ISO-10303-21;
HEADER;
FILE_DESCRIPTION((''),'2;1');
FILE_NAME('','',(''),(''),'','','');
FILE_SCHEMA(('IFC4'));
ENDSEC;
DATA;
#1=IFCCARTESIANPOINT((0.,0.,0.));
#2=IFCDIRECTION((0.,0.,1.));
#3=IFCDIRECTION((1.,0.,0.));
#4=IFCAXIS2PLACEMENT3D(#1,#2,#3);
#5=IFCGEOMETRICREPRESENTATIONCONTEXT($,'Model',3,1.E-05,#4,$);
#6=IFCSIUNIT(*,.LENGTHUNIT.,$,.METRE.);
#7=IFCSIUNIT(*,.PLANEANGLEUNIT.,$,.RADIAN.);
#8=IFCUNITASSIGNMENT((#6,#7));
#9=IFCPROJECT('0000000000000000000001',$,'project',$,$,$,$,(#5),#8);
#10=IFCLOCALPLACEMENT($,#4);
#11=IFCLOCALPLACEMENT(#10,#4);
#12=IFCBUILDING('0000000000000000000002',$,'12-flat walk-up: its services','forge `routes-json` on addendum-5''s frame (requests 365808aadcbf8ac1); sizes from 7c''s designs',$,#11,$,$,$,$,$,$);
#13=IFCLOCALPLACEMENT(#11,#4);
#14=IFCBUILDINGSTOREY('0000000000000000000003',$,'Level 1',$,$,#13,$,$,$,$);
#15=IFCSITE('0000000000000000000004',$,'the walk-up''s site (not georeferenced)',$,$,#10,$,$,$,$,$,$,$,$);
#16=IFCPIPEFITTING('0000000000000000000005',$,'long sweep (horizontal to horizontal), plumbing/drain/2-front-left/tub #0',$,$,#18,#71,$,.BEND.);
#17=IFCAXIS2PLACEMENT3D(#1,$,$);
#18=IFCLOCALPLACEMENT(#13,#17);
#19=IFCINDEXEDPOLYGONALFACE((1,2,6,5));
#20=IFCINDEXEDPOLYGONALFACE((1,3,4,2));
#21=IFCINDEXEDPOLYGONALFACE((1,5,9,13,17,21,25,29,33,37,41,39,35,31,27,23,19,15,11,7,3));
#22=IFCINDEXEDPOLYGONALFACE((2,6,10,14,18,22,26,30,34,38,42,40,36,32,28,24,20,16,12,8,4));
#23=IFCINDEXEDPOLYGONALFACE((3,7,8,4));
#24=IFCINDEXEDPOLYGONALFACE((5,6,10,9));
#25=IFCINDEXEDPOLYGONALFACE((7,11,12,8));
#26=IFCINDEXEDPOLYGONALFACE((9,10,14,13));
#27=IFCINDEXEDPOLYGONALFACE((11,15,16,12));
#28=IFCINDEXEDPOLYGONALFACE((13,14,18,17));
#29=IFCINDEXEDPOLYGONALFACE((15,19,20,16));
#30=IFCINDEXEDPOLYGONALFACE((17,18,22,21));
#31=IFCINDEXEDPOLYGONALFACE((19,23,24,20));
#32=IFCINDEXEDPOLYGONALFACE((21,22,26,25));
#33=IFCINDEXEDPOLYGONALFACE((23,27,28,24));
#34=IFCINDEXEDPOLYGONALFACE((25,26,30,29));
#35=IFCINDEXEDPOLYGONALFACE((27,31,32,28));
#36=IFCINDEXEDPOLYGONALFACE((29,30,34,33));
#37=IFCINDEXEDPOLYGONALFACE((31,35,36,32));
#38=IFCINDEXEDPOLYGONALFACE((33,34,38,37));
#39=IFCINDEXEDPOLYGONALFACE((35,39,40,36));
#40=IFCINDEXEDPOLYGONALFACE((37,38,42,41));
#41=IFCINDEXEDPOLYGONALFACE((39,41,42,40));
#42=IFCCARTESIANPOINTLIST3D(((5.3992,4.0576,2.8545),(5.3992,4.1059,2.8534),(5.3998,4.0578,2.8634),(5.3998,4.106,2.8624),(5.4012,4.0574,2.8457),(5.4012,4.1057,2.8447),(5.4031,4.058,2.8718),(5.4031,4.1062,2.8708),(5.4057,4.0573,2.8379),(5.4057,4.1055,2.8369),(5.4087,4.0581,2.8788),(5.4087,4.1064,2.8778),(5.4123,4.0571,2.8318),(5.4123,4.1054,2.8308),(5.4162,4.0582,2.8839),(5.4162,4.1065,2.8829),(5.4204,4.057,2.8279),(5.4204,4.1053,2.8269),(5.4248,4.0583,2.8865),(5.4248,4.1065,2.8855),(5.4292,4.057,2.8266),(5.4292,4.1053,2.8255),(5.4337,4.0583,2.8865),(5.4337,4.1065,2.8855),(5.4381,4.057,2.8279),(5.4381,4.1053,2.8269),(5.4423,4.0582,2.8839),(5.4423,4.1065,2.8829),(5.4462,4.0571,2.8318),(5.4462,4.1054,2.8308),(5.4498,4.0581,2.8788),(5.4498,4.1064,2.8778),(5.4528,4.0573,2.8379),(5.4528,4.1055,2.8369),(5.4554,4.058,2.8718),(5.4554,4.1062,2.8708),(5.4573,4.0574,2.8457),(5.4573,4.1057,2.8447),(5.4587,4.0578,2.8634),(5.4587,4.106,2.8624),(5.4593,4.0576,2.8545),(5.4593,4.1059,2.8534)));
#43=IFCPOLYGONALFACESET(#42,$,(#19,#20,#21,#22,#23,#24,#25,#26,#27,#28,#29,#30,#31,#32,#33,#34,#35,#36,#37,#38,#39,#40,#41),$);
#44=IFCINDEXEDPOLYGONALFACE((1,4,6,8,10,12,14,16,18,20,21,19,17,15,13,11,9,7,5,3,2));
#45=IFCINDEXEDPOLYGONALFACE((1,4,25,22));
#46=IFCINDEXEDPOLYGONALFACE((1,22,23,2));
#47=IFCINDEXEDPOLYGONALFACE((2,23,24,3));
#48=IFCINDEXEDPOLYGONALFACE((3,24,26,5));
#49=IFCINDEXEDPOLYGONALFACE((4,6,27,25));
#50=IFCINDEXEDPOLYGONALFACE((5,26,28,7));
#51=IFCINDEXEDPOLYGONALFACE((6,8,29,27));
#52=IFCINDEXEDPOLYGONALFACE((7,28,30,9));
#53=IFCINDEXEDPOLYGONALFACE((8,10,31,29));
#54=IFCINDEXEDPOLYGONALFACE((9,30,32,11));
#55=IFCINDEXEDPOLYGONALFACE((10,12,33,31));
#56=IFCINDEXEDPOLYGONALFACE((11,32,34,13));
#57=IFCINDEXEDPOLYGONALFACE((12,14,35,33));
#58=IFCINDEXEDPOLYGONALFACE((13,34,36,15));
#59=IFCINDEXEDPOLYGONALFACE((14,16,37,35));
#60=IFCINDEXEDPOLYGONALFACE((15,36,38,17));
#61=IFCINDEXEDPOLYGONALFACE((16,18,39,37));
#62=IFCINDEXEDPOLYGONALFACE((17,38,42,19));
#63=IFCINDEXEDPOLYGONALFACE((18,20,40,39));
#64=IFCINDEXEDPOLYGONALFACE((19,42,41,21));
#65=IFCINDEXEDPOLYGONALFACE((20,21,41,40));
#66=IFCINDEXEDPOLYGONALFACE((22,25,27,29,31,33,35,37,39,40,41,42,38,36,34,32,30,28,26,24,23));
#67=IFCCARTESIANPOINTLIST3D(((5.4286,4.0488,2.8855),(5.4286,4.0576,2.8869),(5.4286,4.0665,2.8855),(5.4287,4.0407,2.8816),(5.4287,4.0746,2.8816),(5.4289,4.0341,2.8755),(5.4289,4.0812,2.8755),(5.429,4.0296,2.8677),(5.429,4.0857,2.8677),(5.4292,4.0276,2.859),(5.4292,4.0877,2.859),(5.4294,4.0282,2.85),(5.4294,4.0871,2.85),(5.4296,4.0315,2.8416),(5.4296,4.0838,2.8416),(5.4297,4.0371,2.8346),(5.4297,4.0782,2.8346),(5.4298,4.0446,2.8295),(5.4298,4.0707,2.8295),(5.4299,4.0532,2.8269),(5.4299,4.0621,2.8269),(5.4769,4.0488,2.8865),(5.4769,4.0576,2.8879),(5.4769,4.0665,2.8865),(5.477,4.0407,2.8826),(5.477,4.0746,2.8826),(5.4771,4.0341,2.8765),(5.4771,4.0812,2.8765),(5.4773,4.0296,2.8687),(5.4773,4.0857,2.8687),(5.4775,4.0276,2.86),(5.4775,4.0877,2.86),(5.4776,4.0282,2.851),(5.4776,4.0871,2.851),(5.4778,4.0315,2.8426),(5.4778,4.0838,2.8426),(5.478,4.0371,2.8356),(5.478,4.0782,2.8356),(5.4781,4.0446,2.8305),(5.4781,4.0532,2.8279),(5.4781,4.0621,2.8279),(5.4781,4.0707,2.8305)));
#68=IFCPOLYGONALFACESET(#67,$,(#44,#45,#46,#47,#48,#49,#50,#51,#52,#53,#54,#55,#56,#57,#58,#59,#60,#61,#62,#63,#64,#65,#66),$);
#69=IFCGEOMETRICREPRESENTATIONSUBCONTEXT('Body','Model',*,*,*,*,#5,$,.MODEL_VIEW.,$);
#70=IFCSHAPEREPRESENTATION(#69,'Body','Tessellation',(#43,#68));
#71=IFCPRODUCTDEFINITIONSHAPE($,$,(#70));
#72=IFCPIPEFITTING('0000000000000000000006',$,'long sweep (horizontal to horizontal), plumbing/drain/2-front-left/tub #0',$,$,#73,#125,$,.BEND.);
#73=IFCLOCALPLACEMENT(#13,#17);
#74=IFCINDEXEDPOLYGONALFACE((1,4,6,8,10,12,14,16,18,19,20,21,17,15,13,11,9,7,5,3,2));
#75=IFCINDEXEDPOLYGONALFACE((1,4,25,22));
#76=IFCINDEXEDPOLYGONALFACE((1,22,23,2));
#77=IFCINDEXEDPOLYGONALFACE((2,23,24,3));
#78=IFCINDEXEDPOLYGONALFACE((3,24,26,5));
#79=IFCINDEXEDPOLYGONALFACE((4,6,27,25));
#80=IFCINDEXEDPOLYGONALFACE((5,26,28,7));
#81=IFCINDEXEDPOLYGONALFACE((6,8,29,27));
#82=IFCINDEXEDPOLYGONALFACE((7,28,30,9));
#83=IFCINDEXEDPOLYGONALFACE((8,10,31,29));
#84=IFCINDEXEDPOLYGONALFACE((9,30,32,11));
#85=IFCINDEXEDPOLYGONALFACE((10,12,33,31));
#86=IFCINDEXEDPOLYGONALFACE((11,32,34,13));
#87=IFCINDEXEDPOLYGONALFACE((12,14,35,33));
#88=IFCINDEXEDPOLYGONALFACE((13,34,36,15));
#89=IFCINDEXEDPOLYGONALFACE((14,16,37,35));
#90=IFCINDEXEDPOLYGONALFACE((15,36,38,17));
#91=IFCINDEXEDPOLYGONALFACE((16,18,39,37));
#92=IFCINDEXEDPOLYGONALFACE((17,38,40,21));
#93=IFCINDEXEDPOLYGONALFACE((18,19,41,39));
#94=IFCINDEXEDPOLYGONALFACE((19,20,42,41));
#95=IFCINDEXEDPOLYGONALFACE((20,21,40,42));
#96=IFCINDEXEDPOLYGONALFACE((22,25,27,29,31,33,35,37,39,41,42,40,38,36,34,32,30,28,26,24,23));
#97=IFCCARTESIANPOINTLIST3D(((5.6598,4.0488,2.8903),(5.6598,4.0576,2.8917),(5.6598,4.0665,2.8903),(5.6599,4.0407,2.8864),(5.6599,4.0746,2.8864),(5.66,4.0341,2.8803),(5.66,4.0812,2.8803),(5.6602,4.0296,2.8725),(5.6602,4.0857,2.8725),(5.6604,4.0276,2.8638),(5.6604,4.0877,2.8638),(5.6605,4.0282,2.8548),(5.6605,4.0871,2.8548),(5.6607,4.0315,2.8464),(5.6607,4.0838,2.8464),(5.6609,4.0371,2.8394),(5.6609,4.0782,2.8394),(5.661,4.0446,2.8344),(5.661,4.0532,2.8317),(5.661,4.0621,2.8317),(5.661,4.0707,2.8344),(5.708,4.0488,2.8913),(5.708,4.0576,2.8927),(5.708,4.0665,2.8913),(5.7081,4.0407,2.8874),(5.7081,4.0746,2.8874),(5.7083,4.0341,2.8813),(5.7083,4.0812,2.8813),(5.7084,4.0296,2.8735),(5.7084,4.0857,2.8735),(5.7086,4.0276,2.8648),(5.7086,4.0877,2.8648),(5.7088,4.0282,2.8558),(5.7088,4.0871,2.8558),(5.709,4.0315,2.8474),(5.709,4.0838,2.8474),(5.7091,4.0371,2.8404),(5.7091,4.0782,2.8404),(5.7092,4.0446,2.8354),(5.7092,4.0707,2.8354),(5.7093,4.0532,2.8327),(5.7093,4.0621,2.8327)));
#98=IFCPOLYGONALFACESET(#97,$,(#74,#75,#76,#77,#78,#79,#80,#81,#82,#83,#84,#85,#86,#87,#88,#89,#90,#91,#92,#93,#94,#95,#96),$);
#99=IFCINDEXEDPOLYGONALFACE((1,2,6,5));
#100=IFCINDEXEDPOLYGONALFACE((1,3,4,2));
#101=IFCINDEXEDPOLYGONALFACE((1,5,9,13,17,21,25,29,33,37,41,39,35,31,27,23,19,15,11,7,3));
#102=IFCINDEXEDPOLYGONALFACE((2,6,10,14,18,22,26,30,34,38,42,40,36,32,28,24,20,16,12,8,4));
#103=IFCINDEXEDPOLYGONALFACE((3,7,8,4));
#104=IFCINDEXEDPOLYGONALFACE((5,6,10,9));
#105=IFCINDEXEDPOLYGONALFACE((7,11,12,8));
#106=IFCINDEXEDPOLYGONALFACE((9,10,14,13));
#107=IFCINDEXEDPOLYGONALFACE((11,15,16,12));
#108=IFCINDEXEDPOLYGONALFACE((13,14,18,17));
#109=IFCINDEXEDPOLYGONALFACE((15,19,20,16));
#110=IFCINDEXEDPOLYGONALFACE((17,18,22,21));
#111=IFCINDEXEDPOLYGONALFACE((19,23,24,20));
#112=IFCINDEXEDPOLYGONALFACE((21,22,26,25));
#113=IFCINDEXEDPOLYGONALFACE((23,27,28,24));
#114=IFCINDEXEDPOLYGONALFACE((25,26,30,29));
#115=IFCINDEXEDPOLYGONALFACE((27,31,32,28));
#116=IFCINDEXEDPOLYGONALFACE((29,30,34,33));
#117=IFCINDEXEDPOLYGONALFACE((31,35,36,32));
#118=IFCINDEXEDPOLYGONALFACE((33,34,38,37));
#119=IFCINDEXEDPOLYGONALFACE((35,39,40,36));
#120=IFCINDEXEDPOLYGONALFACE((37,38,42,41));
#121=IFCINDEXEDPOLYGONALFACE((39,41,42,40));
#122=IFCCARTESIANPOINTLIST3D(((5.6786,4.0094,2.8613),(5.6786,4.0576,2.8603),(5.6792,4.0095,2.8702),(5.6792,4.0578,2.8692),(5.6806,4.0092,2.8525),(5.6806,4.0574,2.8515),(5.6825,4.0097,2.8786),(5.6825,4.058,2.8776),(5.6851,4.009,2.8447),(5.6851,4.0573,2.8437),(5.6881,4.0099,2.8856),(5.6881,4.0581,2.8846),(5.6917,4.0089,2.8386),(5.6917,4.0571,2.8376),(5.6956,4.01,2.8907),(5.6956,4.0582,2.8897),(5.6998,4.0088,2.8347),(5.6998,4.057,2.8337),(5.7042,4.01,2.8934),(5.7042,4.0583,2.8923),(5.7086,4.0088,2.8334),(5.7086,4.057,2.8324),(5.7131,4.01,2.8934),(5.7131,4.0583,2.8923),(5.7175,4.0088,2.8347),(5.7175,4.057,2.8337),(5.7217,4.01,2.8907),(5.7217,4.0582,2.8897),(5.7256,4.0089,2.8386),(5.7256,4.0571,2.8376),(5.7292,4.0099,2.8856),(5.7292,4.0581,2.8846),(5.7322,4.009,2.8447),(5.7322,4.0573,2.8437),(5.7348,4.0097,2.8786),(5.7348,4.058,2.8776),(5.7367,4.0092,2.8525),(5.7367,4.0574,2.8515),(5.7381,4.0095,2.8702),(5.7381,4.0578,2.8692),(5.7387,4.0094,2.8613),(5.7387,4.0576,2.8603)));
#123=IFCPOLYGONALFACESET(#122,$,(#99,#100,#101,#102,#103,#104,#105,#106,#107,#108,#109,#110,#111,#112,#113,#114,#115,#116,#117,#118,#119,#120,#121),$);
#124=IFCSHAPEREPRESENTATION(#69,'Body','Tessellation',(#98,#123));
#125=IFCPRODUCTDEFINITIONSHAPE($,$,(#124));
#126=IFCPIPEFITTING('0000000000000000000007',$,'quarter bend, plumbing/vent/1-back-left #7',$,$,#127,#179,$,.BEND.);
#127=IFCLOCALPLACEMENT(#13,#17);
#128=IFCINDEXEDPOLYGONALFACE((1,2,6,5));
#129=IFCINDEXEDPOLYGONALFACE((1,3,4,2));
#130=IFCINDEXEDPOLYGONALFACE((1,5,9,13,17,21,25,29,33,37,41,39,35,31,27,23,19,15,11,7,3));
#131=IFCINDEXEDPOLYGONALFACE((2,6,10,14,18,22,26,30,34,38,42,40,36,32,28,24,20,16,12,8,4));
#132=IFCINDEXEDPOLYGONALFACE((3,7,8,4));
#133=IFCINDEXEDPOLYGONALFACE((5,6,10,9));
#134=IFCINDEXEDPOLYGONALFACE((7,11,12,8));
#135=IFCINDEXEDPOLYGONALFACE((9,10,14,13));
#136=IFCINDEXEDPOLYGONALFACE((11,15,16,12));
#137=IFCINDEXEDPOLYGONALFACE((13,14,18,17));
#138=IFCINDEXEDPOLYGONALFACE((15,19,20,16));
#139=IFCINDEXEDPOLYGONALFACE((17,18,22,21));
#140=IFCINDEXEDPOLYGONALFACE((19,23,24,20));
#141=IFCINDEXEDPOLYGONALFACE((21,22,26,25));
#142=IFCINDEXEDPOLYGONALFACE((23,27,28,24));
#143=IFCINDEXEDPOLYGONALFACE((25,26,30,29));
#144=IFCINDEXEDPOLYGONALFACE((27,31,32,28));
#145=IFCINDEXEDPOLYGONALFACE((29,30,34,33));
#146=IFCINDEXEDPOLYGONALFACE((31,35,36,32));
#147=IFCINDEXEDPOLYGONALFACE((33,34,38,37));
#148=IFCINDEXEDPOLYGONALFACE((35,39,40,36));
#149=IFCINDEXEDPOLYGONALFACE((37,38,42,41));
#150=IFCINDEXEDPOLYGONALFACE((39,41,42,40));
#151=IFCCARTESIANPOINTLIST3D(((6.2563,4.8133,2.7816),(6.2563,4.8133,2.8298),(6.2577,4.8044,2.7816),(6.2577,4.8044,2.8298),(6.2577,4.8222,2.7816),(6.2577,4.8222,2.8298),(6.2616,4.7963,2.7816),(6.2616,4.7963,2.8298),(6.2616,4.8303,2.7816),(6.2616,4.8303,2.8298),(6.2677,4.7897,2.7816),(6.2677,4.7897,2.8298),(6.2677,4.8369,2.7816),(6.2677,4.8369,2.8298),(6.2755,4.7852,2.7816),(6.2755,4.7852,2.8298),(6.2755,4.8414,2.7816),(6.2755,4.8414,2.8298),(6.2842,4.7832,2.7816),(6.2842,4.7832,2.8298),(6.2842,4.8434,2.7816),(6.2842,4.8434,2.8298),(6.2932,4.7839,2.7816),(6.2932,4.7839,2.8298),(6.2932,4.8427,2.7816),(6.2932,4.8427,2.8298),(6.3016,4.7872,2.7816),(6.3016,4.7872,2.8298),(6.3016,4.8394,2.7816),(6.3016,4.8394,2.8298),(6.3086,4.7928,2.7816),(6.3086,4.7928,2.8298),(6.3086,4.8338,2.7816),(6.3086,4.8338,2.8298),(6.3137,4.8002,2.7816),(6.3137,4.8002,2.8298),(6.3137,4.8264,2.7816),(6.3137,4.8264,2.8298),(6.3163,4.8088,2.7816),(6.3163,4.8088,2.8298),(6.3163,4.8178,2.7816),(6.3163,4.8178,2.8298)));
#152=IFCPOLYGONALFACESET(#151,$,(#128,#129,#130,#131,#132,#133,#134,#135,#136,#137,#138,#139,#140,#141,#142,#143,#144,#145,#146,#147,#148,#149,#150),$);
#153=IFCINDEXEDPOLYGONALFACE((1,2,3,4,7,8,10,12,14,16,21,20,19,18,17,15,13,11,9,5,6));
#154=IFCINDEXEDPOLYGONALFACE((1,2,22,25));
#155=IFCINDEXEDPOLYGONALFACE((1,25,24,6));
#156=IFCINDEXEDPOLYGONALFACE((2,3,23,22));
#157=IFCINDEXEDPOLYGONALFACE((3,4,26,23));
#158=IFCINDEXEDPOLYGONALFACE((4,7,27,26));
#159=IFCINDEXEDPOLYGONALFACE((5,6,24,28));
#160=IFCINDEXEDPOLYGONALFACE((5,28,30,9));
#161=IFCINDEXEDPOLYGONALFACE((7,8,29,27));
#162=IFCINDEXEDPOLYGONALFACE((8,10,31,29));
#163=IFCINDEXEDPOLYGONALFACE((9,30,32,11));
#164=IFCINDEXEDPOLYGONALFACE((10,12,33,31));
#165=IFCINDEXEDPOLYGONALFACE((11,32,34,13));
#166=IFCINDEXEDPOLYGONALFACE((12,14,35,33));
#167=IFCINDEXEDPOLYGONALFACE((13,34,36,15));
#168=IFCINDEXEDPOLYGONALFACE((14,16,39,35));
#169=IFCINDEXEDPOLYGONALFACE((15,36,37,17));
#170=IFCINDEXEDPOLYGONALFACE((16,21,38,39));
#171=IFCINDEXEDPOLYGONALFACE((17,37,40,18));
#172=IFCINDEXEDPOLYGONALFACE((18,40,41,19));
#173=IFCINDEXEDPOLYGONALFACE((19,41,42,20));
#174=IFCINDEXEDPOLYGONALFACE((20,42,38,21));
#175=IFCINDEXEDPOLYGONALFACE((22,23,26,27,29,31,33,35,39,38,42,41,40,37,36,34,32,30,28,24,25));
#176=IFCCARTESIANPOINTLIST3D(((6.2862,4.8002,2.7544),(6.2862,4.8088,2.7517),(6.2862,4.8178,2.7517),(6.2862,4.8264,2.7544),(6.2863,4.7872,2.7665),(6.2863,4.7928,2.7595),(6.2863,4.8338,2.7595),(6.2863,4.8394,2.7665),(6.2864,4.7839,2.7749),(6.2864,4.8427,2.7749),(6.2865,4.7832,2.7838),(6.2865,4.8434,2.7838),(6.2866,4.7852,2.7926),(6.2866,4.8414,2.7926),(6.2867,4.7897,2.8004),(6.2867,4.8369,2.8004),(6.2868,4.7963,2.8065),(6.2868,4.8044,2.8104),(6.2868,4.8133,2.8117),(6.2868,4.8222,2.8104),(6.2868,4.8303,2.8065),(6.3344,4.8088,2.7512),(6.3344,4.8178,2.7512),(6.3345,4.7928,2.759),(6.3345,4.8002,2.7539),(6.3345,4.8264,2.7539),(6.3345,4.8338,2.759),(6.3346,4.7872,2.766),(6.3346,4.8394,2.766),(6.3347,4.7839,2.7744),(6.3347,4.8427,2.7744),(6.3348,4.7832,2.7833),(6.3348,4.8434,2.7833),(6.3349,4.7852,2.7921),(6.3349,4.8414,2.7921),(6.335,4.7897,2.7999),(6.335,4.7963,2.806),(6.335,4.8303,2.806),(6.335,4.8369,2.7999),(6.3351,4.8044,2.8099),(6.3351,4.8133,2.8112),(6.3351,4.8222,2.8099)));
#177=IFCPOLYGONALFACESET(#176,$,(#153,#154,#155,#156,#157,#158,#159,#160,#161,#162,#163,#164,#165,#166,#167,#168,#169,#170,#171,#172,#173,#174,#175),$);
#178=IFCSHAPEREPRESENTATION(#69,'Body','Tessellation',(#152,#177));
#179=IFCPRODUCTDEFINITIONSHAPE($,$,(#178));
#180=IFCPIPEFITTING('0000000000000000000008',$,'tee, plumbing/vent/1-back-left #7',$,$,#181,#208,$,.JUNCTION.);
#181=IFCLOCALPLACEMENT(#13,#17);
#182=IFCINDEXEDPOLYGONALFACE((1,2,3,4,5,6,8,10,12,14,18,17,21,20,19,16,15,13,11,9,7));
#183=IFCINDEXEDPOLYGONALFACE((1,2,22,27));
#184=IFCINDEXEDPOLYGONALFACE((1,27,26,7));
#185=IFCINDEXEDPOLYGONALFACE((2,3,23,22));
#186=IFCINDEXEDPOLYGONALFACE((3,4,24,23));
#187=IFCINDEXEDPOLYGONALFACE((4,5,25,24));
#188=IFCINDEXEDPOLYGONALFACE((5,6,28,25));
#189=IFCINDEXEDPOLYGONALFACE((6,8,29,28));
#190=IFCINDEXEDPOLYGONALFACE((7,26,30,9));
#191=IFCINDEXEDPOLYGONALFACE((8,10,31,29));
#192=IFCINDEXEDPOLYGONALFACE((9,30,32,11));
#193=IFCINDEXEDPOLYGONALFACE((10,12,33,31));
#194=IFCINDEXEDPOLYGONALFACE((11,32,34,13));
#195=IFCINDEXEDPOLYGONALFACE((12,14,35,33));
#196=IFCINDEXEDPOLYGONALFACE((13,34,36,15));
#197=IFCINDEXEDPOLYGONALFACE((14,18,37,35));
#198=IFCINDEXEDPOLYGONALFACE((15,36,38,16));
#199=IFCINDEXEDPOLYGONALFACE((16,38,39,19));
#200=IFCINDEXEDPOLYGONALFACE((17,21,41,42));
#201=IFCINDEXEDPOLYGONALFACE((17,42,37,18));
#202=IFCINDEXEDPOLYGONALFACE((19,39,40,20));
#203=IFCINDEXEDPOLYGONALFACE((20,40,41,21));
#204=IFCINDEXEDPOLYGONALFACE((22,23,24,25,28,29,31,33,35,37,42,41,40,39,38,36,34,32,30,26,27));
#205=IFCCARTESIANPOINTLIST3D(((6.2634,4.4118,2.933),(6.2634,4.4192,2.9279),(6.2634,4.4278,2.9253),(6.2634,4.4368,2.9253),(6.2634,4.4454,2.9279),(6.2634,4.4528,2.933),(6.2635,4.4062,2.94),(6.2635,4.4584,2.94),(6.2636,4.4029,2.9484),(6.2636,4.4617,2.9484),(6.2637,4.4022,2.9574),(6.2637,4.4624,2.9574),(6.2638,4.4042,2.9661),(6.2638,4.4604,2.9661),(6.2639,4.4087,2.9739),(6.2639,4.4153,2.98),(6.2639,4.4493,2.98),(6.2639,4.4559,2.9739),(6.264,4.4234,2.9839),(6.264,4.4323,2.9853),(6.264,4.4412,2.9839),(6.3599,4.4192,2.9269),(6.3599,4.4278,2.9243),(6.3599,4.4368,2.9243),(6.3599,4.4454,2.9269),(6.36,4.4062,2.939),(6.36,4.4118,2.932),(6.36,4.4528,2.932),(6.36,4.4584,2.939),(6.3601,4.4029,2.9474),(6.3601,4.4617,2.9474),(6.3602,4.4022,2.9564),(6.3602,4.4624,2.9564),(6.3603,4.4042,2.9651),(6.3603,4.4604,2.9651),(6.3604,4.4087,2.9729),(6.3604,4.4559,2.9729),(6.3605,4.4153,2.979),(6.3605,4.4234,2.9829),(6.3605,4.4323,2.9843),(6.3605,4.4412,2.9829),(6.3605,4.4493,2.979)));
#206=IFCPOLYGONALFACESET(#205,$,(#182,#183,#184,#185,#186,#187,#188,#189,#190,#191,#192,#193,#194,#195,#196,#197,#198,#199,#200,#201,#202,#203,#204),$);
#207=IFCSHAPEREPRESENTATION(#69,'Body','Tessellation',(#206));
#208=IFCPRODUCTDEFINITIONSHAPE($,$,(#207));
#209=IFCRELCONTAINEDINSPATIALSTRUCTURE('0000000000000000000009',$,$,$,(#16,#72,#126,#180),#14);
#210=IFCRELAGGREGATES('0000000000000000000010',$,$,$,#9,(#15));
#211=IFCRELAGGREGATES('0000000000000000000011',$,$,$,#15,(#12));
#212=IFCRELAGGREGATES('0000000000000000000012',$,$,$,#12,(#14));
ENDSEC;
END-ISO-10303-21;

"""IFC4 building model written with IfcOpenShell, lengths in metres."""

from ifc_helpers import new_model, entity, si_unit, frame, origin_with_axes, place, context, subcontext, project, spatial, element, save


model = new_model("IFC4")

# Units and contexts
model_context = context("Model", 3, precision=1e-05, world=origin_with_axes())
body_context = subcontext(model_context, "Body", "Model", "MODEL_VIEW")
ifc_project = project(units=[si_unit("LENGTHUNIT", "METRE"), si_unit("PLANEANGLEUNIT", "RADIAN")], contexts=[model_context])

# Site, building, storey
site_placement = place(None, origin_with_axes())
site = spatial("IfcSite", under=ifc_project, at=site_placement, Name="the walk-up's site (not georeferenced)")
building_placement = place(site_placement, origin_with_axes())
building = spatial("IfcBuilding", under=site, at=building_placement, Name="12-flat walk-up: its services", Description="forge `routes-json` on addendum-5's frame (requests 365808aadcbf8ac1); sizes from 7c's designs")
storey_placement = place(building_placement, origin_with_axes())
storey = spatial("IfcBuildingStorey", under=building, at=storey_placement, Name="Level 1")

# Pipe fittings
pipe_fitting_1_placement = place(storey_placement, frame((5.4292, 4.1059, 2.8557), z_axis=(0.0, 0.0, 1.0), x_axis=(1.0, 0.0, 0.0)))
element("IfcPipeFitting", 1, at=pipe_fitting_1_placement, inside=storey, Name="long sweep (horizontal to horizontal), plumbing/drain/2-front-left/tub #0", PredefinedType="BEND", context=body_context, shape_type="AdvancedSweptSolid", body=[
    entity("IfcSweptDiskSolid", entity("IfcPolyline", [entity("IfcCartesianPoint", [0.0, 0.0, 0.0]), entity("IfcCartesianPoint", [0.0, -0.0482, 0.001])]), 0.0302),
    entity("IfcSweptDiskSolid", entity("IfcPolyline", [entity("IfcCartesianPoint", [0.0, -0.0482, 0.001]), entity("IfcCartesianPoint", [0.0482, -0.0482, 0.002])]), 0.0302),
])
pipe_fitting_2_placement = place(storey_placement, frame((5.6604, 4.0576, 2.8615), z_axis=(0.0, 0.0, 1.0), x_axis=(1.0, 0.0, 0.0)))
element("IfcPipeFitting", 2, at=pipe_fitting_2_placement, inside=storey, Name="long sweep (horizontal to horizontal), plumbing/drain/2-front-left/tub #0", PredefinedType="BEND", context=body_context, shape_type="AdvancedSweptSolid", body=[
    entity("IfcSweptDiskSolid", entity("IfcPolyline", [entity("IfcCartesianPoint", [0.0, 0.0, 0.0]), entity("IfcCartesianPoint", [0.0482, 0.0, 0.001])]), 0.0302),
    entity("IfcSweptDiskSolid", entity("IfcPolyline", [entity("IfcCartesianPoint", [0.0482, 0.0, 0.001]), entity("IfcCartesianPoint", [0.0482, -0.0482, 0.002])]), 0.0302),
])

# Pipe fittings
pipe_fitting_3_placement = place(storey_placement, frame((6.2865, 4.8133, 2.8298), z_axis=(0.0, 0.0, 1.0), x_axis=(1.0, 0.0, 0.0)))
element("IfcPipeFitting", 3, at=pipe_fitting_3_placement, inside=storey, Name="quarter bend, plumbing/vent/1-back-left #7", PredefinedType="BEND", context=body_context, shape_type="AdvancedSweptSolid", body=[
    entity("IfcSweptDiskSolid", entity("IfcPolyline", [entity("IfcCartesianPoint", [0.0, 0.0, 0.0]), entity("IfcCartesianPoint", [0.0, 0.0, -0.0483])]), 0.0302),
    entity("IfcSweptDiskSolid", entity("IfcPolyline", [entity("IfcCartesianPoint", [0.0, 0.0, -0.0483]), entity("IfcCartesianPoint", [0.0483, 0.0, -0.0488])]), 0.0302),
])
pipe_fitting_4_placement = place(storey_placement, frame((6.2637, 4.4323, 2.9551), z_axis=(0.0, 0.0, 1.0), x_axis=(1.0, 0.0, 0.0)))
element("IfcPipeFitting", 4, at=pipe_fitting_4_placement, inside=storey, Name="tee, plumbing/vent/1-back-left #7", PredefinedType="JUNCTION", context=body_context, shape_type="AdvancedSweptSolid", body=[
    entity("IfcSweptDiskSolid", entity("IfcPolyline", [entity("IfcCartesianPoint", [0.0, 0.0, 0.0]), entity("IfcCartesianPoint", [0.0965, 0.0, -0.001])]), 0.0302),
])

save(model, "model.ifc")
